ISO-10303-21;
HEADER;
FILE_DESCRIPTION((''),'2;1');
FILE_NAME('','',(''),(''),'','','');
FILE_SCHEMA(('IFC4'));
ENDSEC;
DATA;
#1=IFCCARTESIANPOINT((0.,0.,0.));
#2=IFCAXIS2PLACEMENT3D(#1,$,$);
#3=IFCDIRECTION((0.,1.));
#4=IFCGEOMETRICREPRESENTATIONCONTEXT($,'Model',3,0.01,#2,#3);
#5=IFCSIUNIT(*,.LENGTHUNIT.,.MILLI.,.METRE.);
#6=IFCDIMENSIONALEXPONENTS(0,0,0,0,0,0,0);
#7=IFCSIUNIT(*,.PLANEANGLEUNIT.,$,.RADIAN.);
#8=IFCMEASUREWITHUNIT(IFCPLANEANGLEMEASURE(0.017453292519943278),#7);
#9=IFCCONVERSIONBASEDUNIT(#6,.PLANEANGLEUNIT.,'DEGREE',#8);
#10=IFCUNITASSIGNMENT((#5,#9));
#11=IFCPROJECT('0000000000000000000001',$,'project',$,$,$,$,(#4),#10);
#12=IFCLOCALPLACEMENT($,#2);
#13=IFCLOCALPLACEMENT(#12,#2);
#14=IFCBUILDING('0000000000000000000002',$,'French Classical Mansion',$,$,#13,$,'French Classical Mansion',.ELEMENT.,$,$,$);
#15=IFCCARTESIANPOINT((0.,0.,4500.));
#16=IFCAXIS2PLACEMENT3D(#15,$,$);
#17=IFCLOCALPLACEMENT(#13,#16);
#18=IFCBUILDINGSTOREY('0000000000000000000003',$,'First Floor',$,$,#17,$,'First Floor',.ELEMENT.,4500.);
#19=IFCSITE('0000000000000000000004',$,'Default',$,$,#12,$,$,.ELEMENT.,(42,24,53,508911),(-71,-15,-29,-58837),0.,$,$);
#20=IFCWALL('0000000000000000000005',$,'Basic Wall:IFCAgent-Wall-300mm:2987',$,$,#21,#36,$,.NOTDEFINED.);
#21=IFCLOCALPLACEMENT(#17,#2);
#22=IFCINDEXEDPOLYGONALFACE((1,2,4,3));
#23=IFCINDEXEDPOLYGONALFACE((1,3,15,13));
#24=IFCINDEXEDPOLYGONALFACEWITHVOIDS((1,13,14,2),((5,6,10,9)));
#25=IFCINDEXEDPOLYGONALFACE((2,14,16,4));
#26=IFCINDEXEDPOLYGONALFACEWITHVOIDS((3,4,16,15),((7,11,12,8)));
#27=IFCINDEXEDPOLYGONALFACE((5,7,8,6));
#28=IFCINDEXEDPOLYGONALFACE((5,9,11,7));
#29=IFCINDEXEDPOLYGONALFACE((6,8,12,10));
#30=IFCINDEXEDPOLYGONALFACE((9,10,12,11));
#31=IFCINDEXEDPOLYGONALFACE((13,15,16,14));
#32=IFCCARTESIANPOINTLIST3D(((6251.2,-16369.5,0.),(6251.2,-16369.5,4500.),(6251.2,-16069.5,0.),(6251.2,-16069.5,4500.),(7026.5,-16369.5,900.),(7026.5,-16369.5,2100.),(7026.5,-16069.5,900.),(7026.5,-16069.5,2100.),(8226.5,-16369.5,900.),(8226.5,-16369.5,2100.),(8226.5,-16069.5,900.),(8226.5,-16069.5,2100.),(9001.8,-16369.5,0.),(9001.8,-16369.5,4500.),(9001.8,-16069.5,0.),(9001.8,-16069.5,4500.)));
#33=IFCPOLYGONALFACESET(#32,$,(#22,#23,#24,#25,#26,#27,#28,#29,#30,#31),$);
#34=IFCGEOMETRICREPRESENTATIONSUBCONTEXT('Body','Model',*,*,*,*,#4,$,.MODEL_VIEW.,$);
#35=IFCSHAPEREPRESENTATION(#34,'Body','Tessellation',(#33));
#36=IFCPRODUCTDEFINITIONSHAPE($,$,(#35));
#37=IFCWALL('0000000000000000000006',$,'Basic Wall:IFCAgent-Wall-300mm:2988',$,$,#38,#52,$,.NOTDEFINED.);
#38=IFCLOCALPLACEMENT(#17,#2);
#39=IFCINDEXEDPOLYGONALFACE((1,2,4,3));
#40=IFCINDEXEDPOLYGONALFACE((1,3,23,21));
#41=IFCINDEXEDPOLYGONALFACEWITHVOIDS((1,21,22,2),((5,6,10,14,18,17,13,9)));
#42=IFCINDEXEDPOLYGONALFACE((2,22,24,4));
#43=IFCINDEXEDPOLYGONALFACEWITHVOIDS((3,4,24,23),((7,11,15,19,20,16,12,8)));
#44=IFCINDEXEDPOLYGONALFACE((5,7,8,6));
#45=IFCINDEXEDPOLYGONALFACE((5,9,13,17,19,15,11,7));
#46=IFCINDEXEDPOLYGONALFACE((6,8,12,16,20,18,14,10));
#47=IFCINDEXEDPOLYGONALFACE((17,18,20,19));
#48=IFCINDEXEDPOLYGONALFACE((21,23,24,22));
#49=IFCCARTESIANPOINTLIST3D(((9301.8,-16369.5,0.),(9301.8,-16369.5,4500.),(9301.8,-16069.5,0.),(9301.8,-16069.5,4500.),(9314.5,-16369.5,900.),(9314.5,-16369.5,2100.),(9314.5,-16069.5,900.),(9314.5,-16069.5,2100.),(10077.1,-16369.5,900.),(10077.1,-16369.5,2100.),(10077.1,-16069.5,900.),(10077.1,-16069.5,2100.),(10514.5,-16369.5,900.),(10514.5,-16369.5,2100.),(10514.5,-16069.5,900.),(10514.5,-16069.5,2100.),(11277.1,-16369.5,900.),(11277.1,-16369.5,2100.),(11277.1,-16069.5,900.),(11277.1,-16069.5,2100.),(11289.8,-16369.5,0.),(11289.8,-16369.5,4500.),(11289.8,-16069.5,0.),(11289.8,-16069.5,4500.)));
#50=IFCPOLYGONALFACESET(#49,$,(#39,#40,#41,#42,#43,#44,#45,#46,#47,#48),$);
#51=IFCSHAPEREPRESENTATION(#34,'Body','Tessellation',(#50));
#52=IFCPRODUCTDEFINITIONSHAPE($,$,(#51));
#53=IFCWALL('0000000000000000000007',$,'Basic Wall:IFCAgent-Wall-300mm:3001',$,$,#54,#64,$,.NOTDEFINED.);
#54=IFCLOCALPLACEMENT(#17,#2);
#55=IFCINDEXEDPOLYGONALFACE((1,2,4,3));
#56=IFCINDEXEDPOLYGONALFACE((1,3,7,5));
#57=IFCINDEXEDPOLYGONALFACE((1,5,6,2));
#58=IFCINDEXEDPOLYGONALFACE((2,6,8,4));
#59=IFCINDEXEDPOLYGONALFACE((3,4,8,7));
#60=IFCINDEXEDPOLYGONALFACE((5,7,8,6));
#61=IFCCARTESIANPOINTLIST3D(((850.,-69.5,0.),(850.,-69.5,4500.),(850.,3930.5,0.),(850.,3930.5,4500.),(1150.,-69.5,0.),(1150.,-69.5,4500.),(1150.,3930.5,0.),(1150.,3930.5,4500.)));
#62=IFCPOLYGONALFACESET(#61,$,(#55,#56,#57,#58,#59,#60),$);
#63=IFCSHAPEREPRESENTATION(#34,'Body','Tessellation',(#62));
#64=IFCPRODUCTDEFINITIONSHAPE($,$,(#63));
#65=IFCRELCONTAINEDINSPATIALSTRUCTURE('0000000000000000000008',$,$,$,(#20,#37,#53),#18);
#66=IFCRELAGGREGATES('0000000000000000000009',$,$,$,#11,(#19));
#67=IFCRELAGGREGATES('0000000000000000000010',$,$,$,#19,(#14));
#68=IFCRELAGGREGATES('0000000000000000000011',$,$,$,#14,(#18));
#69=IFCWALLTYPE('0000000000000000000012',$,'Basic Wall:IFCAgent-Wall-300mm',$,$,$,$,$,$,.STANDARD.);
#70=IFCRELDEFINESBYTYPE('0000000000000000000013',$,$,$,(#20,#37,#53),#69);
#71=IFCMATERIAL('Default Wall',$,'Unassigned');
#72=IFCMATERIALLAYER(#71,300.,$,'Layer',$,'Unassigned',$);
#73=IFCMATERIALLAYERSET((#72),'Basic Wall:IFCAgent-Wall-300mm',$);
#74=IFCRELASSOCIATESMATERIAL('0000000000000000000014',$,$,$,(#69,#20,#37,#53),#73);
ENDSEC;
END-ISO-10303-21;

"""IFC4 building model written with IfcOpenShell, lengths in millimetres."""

from ifc_helpers import new_model, entity, si_unit, converted_unit, direction, frame, frame_2d, origin, place, context, subcontext, project, spatial, rectangle, extrude, material, layer, layer_set, layer_usage, type_object, element, save


model = new_model("IFC4")

# Units and contexts
model_context = context("Model", 3, precision=0.01, world=origin(), true_north=direction((0.0, 1.0)))
body_context = subcontext(model_context, "Body", "Model", "MODEL_VIEW")
ifc_project = project(units=[si_unit("LENGTHUNIT", "METRE", prefix="MILLI"), converted_unit("PLANEANGLEUNIT", "DEGREE", entity("IfcPlaneAngleMeasure", 0.017453292519943278), si_unit("PLANEANGLEUNIT", "RADIAN"), dimensions=[0, 0, 0, 0, 0, 0, 0])], contexts=[model_context])

# Site, building, storey
site_placement = place(None, origin())
site = spatial("IfcSite", under=ifc_project, at=site_placement, Name="Default", CompositionType="ELEMENT", RefLatitude=(42, 24, 53, 508911), RefLongitude=(-71, -15, -29, -58837), RefElevation=0.0)
building_placement = place(site_placement, origin())
building = spatial("IfcBuilding", under=site, at=building_placement, Name="French Classical Mansion", LongName="French Classical Mansion", CompositionType="ELEMENT")
storey_placement = place(building_placement, frame((0.0, 0.0, 4500.0)))
storey = spatial("IfcBuildingStorey", under=building, at=storey_placement, Name="First Floor", LongName="First Floor", CompositionType="ELEMENT", Elevation=4500.0)

# Shared definitions
ifc_material = material(Name="Default Wall", Category="Unassigned")
ifc_layer = layer(ifc_material, 300.0, Name="Layer", Category="Unassigned")
ifc_layer_set = layer_set([ifc_layer], Name="Basic Wall:IFCAgent-Wall-300mm")
wall_type = type_object("IfcWallType", Name="Basic Wall:IFCAgent-Wall-300mm", PredefinedType="STANDARD", material=ifc_layer_set)

# Wall, opening
ifc_layer_usage_1 = layer_usage(ifc_layer_set, "AXIS2", "NEGATIVE", 150.0)
wall_1_placement = place(storey_placement, frame((6251.2, -16219.5, 0.0)))
wall_1 = element("IfcWall", 1, at=wall_1_placement, inside=storey, type_object=wall_type, material=ifc_layer_usage_1, Name="Basic Wall:IFCAgent-Wall-300mm:2987", PredefinedType="NOTDEFINED", context=body_context, shape_type="SweptSolid", body=[
    extrude(rectangle(XDim=2750.6, YDim=300.0, at=frame_2d((1375.3, 0.0), x_axis=(-1.0, 0.0))), origin(), (0.0, 0.0, 1.0), 4500.0),
])
opening_1_placement = place(wall_1_placement, origin())
element("IfcOpeningElement", 2, at=opening_1_placement, cuts=wall_1, PredefinedType="OPENING", context=body_context, shape_type="SweptSolid", body=[
    extrude(rectangle(XDim=1200.0, YDim=1200.0, at=frame_2d((0.0, 0.0), x_axis=(1.0, 0.0))), frame((1375.3, -150.0, 1500.0), z_axis=(0.0, 1.0, 0.0), x_axis=(0.0, 0.0, -1.0)), (0.0, 0.0, 1.0), 300.0),
])

# Wall, openings
ifc_layer_usage_2 = layer_usage(ifc_layer_set, "AXIS2", "NEGATIVE", 150.0)
wall_2_placement = place(storey_placement, frame((9301.8, -16219.5, 0.0)))
wall_2 = element("IfcWall", 3, at=wall_2_placement, inside=storey, type_object=wall_type, material=ifc_layer_usage_2, Name="Basic Wall:IFCAgent-Wall-300mm:2988", PredefinedType="NOTDEFINED", context=body_context, shape_type="SweptSolid", body=[
    extrude(rectangle(XDim=1988.0, YDim=300.0, at=frame_2d((994.0, 0.0), x_axis=(-1.0, 0.0))), origin(), (0.0, 0.0, 1.0), 4500.0),
])
opening_2_placement = place(wall_2_placement, origin())
element("IfcOpeningElement", 4, at=opening_2_placement, cuts=wall_2, PredefinedType="OPENING", context=body_context, shape_type="SweptSolid", body=[
    extrude(rectangle(XDim=1200.0, YDim=1200.0, at=frame_2d((0.0, 0.0), x_axis=(1.0, 0.0))), frame((612.7, -150.0, 1500.0), z_axis=(0.0, 1.0, 0.0), x_axis=(0.0, 0.0, -1.0)), (0.0, 0.0, 1.0), 300.0),
])
opening_3_placement = place(wall_2_placement, origin())
element("IfcOpeningElement", 5, at=opening_3_placement, cuts=wall_2, PredefinedType="OPENING", context=body_context, shape_type="SweptSolid", body=[
    extrude(rectangle(XDim=1200.0, YDim=1200.0, at=frame_2d((0.0, 0.0), x_axis=(1.0, 0.0))), frame((1375.3, -150.0, 1500.0), z_axis=(0.0, 1.0, 0.0), x_axis=(0.0, 0.0, -1.0)), (0.0, 0.0, 1.0), 300.0),
])

# Wall
ifc_layer_usage_3 = layer_usage(ifc_layer_set, "AXIS2", "NEGATIVE", 150.0)
wall_3_placement = place(storey_placement, frame((1000.0, -69.5, 0.0), z_axis=(0.0, 0.0, 1.0), x_axis=(0.0, 1.0, 0.0)))
element("IfcWall", 6, at=wall_3_placement, inside=storey, type_object=wall_type, material=ifc_layer_usage_3, Name="Basic Wall:IFCAgent-Wall-300mm:3001", PredefinedType="NOTDEFINED", context=body_context, shape_type="SweptSolid", body=[
    extrude(rectangle(XDim=4000.0, YDim=300.0, at=frame_2d((2000.0, 0.0), x_axis=(-1.0, 0.0))), origin(), (0.0, 0.0, 1.0), 4500.0),
])

save(model, "model.ifc")
